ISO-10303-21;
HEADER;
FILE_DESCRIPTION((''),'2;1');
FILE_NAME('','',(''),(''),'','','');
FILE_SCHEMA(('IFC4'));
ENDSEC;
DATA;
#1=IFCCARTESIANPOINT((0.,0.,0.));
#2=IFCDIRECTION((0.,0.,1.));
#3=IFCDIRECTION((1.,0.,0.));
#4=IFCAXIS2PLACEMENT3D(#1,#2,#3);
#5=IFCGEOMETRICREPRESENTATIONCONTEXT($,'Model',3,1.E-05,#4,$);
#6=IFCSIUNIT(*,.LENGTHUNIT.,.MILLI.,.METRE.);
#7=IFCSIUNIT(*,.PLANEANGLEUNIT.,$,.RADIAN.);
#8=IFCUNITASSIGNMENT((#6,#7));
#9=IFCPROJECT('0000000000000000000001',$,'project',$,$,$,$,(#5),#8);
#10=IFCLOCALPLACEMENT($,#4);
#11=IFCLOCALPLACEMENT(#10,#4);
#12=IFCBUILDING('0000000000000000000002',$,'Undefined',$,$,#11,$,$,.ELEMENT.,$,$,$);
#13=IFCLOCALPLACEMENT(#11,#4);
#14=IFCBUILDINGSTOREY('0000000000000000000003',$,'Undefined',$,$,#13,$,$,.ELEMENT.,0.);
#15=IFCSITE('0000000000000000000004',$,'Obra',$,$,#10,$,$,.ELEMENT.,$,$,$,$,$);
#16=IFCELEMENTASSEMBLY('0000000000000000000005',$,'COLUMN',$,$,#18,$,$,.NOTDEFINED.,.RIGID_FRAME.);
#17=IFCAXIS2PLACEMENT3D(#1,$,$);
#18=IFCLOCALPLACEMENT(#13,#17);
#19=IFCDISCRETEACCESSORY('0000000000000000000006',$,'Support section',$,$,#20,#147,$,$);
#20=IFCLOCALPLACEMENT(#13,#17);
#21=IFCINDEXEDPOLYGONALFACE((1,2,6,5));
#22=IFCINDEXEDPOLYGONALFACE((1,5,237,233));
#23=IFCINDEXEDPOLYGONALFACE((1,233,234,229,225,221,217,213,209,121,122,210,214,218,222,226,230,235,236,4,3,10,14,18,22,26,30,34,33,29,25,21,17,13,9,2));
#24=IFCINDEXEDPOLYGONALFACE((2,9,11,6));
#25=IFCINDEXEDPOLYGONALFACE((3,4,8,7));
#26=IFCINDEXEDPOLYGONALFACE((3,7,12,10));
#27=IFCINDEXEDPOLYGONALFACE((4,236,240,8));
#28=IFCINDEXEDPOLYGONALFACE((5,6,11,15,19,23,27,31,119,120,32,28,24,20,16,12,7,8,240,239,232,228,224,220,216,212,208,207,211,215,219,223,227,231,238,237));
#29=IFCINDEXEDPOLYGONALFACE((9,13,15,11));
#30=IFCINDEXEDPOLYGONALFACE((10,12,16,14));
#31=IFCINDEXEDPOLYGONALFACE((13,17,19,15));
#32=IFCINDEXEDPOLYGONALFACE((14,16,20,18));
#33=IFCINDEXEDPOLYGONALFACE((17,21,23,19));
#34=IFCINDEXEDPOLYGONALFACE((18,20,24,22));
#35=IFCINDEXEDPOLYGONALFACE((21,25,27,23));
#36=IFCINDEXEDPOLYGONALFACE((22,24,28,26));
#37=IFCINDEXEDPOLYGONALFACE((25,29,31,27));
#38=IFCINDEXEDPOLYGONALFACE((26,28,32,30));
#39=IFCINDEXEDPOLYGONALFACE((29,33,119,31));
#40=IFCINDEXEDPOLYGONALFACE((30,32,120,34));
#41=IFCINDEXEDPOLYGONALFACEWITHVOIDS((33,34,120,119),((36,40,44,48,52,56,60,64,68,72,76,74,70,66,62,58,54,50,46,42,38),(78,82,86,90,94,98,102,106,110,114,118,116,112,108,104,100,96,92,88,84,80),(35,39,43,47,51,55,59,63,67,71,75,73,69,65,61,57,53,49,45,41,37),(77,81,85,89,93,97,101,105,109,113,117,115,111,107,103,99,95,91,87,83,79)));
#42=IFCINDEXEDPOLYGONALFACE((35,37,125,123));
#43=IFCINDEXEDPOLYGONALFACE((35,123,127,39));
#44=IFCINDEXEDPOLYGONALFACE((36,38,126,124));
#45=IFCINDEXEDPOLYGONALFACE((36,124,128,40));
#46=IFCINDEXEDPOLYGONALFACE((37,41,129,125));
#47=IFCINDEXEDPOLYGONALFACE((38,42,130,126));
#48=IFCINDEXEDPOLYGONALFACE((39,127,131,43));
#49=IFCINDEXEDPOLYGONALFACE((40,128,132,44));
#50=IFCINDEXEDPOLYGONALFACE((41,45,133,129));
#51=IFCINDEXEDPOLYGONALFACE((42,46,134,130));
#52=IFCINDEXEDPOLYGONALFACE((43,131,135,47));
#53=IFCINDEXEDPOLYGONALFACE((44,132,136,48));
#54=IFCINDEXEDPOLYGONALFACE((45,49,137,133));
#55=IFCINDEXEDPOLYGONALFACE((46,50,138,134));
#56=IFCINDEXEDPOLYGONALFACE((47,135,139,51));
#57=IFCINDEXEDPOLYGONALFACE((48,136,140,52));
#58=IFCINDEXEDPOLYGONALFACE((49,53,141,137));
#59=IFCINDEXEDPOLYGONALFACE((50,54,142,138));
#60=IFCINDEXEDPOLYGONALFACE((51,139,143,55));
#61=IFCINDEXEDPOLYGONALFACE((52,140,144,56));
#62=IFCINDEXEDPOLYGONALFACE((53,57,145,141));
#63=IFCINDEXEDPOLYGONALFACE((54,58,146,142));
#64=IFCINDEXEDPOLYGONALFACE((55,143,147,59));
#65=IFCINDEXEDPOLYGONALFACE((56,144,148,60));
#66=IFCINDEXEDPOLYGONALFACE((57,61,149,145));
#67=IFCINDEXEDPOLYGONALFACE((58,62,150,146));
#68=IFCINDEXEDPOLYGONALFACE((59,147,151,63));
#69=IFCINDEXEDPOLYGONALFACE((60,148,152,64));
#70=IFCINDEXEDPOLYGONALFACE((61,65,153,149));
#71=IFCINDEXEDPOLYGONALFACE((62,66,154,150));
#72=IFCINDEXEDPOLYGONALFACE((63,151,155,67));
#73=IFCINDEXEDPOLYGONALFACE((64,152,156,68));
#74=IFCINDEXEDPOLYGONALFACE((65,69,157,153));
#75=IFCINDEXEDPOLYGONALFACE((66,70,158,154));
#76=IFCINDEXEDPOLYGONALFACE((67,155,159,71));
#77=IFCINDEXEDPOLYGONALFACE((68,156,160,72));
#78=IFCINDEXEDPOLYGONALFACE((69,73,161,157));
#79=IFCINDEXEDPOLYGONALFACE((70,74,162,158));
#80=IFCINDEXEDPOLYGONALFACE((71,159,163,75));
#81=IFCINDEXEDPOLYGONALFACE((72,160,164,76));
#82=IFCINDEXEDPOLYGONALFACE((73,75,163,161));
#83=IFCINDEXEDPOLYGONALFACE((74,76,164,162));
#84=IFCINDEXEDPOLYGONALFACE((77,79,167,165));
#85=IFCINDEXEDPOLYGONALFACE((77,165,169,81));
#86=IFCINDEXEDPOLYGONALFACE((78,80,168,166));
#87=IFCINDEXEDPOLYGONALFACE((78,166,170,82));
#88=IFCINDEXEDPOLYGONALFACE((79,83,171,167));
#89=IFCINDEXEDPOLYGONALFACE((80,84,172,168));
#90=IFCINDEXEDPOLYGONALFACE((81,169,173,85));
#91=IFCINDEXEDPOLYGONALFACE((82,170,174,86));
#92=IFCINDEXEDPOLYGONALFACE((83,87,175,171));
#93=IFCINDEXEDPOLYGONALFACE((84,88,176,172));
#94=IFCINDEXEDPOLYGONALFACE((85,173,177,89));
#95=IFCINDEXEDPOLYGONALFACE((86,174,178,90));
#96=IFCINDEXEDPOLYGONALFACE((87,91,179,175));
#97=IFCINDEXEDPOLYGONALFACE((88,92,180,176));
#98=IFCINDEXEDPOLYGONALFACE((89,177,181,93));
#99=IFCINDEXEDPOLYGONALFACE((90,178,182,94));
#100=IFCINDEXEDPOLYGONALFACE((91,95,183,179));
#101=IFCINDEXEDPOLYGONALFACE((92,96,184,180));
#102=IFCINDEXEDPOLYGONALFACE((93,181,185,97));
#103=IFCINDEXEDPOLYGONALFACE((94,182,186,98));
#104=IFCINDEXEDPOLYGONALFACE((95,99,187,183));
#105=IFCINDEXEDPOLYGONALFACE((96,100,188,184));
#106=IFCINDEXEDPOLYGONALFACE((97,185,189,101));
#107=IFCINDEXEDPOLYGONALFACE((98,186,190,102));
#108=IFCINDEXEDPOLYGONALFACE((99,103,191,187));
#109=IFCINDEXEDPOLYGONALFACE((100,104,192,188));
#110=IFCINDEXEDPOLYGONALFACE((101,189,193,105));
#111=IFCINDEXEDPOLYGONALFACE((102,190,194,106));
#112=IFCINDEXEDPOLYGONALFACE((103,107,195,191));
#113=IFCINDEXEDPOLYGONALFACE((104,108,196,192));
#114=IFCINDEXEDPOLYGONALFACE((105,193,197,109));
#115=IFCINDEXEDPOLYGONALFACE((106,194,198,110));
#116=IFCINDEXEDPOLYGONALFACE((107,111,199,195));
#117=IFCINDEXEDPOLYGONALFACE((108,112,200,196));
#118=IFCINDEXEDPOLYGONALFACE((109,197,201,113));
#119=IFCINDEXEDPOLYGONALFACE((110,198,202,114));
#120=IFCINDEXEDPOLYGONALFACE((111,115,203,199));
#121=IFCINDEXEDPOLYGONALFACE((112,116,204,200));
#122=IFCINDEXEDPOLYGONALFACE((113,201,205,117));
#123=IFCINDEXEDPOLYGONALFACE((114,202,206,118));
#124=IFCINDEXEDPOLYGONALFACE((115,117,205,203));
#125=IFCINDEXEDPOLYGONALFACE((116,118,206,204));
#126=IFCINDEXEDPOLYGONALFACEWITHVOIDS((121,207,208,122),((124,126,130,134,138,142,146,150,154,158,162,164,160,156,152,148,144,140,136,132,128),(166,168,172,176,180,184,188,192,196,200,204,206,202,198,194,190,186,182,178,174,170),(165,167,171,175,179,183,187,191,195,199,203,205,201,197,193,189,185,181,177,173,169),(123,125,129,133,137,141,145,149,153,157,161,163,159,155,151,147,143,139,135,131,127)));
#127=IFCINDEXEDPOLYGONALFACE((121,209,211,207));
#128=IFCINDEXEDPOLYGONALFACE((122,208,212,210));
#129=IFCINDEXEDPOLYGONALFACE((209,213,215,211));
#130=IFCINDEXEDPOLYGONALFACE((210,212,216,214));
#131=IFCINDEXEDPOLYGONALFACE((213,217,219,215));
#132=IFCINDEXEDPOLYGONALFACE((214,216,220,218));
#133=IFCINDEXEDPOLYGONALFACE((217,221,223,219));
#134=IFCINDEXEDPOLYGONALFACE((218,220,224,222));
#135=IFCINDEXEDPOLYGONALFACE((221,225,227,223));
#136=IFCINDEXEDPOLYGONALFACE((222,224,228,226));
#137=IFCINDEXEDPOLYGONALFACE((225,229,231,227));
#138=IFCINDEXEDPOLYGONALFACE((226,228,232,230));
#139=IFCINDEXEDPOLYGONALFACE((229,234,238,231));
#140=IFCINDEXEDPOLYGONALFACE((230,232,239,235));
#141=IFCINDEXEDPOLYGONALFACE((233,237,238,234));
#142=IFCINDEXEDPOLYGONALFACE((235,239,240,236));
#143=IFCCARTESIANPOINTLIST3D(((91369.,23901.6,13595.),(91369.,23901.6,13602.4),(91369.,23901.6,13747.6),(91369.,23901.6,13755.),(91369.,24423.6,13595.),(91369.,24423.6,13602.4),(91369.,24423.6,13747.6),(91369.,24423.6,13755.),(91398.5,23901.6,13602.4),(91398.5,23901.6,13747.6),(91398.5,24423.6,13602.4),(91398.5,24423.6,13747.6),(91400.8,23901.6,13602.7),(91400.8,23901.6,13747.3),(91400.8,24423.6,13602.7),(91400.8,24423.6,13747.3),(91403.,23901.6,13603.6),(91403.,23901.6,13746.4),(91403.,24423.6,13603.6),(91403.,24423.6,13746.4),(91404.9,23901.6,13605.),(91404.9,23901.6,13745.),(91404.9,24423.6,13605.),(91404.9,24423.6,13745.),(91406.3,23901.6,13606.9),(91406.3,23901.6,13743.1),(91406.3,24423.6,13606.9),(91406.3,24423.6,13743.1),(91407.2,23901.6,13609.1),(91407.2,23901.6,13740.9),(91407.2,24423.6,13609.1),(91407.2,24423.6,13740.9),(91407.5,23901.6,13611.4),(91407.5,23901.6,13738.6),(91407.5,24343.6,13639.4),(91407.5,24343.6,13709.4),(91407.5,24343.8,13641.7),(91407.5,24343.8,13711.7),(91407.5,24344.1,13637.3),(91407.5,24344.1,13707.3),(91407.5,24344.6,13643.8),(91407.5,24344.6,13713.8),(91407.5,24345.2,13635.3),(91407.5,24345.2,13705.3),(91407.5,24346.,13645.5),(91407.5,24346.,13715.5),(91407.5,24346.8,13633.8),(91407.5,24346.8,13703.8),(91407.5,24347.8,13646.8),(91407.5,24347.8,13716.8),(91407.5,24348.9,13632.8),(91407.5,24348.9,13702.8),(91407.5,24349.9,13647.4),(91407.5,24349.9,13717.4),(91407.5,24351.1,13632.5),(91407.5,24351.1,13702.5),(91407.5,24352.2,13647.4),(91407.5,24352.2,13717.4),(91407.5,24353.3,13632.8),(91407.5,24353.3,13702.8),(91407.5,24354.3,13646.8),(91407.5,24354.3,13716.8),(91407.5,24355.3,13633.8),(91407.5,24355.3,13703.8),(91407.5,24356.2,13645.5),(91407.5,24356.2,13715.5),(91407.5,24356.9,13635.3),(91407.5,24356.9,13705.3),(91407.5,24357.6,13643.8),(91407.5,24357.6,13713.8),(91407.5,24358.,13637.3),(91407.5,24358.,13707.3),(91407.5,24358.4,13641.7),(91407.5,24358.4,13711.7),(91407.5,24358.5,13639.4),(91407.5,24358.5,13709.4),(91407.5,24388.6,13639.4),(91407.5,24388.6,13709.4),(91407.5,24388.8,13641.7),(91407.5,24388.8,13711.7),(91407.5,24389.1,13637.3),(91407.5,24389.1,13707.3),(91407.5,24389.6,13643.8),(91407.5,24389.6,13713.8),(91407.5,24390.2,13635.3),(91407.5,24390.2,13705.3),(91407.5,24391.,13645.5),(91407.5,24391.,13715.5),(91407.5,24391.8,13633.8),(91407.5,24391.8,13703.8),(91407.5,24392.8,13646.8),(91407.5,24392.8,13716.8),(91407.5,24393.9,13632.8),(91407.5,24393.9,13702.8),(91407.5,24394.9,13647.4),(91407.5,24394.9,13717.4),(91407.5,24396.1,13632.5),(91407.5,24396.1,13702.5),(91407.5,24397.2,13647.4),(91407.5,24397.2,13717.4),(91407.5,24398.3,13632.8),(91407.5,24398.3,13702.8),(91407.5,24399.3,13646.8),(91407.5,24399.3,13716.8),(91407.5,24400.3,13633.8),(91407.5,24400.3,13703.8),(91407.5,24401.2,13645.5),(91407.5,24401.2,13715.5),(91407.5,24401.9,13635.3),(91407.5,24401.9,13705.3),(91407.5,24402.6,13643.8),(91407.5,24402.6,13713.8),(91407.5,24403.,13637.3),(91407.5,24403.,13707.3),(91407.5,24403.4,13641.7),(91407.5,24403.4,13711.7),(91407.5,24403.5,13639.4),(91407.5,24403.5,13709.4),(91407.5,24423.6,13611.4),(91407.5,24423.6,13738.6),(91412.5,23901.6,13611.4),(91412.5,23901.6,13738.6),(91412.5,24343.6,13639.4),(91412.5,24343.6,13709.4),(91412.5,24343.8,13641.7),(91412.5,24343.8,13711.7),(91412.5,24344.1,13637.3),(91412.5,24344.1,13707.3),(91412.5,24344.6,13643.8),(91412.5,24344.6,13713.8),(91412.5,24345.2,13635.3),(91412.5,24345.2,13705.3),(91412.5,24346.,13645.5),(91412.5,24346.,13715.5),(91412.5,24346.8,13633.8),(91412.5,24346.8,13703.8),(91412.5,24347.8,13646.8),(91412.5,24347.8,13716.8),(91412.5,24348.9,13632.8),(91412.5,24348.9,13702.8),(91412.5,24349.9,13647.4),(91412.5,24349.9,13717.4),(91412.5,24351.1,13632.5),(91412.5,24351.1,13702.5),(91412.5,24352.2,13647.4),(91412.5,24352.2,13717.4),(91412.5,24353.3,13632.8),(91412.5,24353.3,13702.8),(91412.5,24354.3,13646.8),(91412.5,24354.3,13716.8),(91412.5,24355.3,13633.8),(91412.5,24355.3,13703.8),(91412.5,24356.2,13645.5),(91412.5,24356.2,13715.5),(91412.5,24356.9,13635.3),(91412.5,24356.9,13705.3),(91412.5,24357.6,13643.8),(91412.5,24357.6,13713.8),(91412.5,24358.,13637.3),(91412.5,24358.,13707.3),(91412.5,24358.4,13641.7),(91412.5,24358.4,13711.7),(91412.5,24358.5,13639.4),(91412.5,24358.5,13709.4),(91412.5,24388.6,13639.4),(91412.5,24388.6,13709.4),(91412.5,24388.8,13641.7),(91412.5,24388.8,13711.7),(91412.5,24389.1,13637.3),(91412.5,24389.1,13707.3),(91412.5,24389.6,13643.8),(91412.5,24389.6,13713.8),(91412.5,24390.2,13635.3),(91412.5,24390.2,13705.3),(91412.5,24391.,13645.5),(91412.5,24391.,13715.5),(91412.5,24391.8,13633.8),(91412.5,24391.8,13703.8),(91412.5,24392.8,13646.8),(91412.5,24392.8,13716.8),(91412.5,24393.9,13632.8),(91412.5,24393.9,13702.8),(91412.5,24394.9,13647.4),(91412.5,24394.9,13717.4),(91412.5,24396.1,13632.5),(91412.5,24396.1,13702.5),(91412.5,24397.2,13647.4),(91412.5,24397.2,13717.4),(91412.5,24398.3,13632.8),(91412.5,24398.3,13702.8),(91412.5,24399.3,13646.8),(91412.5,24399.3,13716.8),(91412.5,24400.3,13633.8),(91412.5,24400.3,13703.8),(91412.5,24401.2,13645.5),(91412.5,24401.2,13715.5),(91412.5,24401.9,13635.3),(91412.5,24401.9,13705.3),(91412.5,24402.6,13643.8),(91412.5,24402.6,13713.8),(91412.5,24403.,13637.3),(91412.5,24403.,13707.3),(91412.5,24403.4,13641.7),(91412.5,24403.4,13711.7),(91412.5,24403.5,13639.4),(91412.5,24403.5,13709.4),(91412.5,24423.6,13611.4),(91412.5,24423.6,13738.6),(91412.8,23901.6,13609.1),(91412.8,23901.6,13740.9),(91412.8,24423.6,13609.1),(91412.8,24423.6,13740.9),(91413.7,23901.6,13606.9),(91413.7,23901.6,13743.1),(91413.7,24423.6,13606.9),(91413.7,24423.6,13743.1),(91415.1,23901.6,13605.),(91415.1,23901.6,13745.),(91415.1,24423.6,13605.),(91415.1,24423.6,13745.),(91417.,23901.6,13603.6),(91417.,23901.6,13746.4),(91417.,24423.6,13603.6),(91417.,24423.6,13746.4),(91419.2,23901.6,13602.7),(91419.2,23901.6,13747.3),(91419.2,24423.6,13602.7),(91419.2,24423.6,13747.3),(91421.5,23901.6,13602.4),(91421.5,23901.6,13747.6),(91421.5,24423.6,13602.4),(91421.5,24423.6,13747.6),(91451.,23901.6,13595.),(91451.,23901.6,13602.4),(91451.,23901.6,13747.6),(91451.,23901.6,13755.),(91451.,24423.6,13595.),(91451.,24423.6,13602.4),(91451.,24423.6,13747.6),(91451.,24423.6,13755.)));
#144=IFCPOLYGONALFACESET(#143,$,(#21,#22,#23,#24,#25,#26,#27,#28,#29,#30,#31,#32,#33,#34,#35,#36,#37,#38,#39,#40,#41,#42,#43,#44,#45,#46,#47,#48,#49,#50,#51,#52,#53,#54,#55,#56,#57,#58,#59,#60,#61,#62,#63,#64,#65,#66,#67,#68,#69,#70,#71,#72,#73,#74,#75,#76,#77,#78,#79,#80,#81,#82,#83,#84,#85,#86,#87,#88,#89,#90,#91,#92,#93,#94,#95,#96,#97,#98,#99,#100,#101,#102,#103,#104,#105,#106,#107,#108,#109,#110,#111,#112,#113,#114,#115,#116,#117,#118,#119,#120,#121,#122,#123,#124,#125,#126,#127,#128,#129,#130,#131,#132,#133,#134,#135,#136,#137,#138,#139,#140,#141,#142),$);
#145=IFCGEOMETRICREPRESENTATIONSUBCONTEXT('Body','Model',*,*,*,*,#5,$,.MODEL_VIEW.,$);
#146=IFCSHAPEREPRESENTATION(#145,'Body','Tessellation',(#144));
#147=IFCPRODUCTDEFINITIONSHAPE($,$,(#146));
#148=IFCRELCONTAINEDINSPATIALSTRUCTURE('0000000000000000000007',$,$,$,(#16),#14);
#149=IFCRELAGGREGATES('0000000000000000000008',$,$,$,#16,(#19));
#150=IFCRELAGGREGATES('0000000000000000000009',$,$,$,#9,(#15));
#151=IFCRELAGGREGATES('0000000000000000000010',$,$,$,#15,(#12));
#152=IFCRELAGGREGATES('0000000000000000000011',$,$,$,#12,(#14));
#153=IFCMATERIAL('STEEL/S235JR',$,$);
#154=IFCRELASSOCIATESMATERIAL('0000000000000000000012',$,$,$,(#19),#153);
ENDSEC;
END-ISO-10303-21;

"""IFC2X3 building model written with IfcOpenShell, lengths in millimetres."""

from ifc_helpers import new_model, si_unit, frame, origin_with_axes, origin_2d_with_axis, place, context, subcontext, project, spatial, circle, i_section, extrude, clip, halfspace, source, transform, mapped, material, element, aggregate, save


model = new_model("IFC2X3")

# Units and contexts
model_context = context("Model", 3, precision=1e-05, world=origin_with_axes())
body_context = subcontext(model_context, "Body", "Model", "MODEL_VIEW")
ifc_project = project(units=[si_unit("LENGTHUNIT", "METRE", prefix="MILLI"), si_unit("PLANEANGLEUNIT", "RADIAN")], contexts=[model_context])

# Site, building, storey
site_placement = place(None, origin_with_axes())
site = spatial("IfcSite", under=ifc_project, at=site_placement, Name="Obra", CompositionType="ELEMENT")
building_placement = place(site_placement, origin_with_axes())
building = spatial("IfcBuilding", under=site, at=building_placement, Name="Undefined", CompositionType="ELEMENT")
storey_placement = place(building_placement, origin_with_axes())
storey = spatial("IfcBuildingStorey", under=building, at=storey_placement, Name="Undefined", CompositionType="ELEMENT", Elevation=0.0)

# Shared definitions
ifc_material_1 = material(Name="STEEL/S235JR")

# Element assembly
assembly_1_placement = place(storey_placement, origin_with_axes())
assembly_1 = element("IfcElementAssembly", 1, at=assembly_1_placement, inside=storey, Name="COLUMN", AssemblyPlace="NOTDEFINED", PredefinedType="RIGID_FRAME")

# Discrete accessory, opening
discrete_accessory_1_placement = place(assembly_1_placement, frame((91410.0, 23901.0, 13675.0), z_axis=(0.0, 0.0, 1.0), x_axis=(0.0, 1.0, 0.0)))
discrete_accessory_1 = element("IfcDiscreteAccessory", 2, at=discrete_accessory_1_placement, material=ifc_material_1, Name="Support section", context=body_context, shape_type="Clipping", body=[
    clip(clip(extrude(i_section(OverallWidth=82.0, OverallDepth=160.0, WebThickness=5.0, FlangeThickness=7.4, FilletRadius=9.0, at=origin_2d_with_axis()), frame((522.6, 0.0, 0.0), z_axis=(-1.0, 0.0, 0.0), x_axis=(0.0, -1.0, 0.0)), (0.0, 0.0, 1.0), 522.0), halfspace(frame((522.6, 0.0, -180.0), z_axis=(-1.0, 0.0, 0.0), x_axis=(0.0, 1.0, 0.0)), True)), halfspace(frame((0.6, 0.0, 580.0), z_axis=(-1.0, 0.0, 0.0), x_axis=(0.0, -1.0, 0.0)), False)),
])
shared_shape_1 = source(origin_with_axes(), body_context, "Body", "SweptSolid", [
    extrude(circle(Radius=7.5, at=origin_2d_with_axis()), frame((0.0, -2.6, 0.0), z_axis=(0.0, 1.0, 0.0), x_axis=(1.0, 0.0, 0.0)), (0.0, 0.0, 1.0), 5.2),
])
opening_1_placement = place(assembly_1_placement, frame((91410.0, 24373.6, 13710.0), z_axis=(0.0, -1.0, 0.0), x_axis=(0.0, 0.0, -1.0)))
element("IfcOpeningElement", 3, at=opening_1_placement, cuts=discrete_accessory_1, ObjectType="Opening", context=body_context, shape_type="MappedRepresentation", body=[
    mapped(shared_shape_1, transform((0.0, 0.0, -22.5))),
    mapped(shared_shape_1, transform((70.0, 0.0, -22.5))),
    mapped(shared_shape_1, transform((0.0, 0.0, 22.5))),
    mapped(shared_shape_1, transform((70.0, 0.0, 22.5))),
])
aggregate(assembly_1, [discrete_accessory_1])

save(model, "model.ifc")
